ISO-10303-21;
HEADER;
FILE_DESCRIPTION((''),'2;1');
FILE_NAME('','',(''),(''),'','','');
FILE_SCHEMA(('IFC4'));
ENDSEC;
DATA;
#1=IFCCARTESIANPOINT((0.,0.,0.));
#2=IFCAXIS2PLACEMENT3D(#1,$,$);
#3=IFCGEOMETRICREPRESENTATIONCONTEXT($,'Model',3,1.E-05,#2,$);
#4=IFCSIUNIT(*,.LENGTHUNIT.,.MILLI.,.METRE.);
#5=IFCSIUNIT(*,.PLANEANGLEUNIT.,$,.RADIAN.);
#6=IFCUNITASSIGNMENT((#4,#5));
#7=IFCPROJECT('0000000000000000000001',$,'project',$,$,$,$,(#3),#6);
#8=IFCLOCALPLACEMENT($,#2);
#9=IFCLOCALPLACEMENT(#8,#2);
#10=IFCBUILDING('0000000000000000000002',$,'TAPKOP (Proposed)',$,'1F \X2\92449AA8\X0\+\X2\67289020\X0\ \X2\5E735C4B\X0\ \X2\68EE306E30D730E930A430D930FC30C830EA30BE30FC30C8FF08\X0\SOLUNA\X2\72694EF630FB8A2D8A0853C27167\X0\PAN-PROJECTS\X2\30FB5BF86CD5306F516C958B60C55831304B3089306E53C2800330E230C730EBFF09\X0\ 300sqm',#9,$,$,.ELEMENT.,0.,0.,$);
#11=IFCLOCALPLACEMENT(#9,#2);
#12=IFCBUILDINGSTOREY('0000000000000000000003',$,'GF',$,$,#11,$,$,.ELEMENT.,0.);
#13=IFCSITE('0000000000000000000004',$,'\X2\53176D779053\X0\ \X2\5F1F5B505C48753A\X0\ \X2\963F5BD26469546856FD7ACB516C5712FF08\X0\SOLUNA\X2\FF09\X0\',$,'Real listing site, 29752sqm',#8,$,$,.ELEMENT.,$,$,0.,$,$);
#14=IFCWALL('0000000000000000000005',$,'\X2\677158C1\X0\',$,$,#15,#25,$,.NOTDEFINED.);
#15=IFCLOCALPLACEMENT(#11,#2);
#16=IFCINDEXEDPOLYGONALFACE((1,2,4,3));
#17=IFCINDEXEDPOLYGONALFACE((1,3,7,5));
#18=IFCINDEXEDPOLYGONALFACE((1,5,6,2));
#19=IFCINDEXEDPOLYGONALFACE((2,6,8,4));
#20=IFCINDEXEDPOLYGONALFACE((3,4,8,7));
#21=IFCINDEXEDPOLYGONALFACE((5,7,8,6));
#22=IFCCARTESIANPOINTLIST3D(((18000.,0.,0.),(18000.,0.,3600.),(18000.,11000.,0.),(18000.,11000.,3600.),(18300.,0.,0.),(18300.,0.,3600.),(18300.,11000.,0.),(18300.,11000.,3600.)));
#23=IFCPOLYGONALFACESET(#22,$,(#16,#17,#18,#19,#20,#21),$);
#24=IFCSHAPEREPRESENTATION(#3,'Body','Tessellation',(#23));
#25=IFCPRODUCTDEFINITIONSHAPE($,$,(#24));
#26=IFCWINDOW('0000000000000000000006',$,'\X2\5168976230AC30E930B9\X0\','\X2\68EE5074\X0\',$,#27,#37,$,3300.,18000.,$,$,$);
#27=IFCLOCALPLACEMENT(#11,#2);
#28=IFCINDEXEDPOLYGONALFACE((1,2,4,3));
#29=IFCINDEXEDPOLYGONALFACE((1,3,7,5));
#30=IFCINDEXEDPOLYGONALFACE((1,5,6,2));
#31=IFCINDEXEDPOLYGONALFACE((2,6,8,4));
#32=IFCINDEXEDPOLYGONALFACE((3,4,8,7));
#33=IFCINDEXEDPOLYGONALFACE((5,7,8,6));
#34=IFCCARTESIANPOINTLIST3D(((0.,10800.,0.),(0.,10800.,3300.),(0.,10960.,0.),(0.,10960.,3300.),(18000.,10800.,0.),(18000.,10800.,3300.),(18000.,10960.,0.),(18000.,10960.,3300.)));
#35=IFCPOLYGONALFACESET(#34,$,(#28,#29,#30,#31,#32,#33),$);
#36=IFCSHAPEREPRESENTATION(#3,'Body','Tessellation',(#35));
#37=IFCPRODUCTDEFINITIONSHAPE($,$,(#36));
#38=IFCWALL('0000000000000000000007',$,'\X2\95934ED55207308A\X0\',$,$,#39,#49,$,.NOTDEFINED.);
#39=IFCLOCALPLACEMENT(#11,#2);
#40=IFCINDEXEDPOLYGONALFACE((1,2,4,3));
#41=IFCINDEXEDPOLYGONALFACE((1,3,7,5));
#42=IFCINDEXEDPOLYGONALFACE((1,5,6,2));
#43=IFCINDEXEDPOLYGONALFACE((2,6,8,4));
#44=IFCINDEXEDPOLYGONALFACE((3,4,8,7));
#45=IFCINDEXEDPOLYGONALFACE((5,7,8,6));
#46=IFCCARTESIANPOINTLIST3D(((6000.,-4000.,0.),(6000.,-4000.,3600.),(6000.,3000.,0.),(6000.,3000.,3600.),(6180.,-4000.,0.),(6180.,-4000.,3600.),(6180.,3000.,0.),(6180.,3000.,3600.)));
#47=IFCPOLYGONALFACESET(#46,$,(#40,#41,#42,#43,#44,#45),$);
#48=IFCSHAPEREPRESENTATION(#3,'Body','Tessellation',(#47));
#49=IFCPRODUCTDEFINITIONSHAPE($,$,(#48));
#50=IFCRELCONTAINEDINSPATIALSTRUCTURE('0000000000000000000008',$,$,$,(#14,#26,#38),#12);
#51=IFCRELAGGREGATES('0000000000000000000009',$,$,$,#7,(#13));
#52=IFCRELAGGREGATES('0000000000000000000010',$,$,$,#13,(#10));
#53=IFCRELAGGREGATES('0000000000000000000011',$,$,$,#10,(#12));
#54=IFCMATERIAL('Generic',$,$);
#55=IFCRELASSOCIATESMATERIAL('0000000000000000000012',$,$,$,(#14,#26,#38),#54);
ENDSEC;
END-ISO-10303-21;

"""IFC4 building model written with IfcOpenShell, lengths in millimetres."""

from ifc_helpers import new_model, si_unit, frame, frame_2d, origin, place, context, project, spatial, rectangle, extrude, material, element, fill, save


model = new_model("IFC4")

# Units and contexts
model_context = context("Model", 3, precision=1e-05, world=origin())
ifc_project = project(units=[si_unit("LENGTHUNIT", "METRE", prefix="MILLI"), si_unit("PLANEANGLEUNIT", "RADIAN")], contexts=[model_context])

# Site, building, storey
site_placement = place(None, origin())
site = spatial("IfcSite", under=ifc_project, at=site_placement, Name="北海道 弟子屈町 阿寒摩周国立公園（SOLUNA）", ObjectType="Real listing site, 29752sqm", CompositionType="ELEMENT", RefElevation=0.0)
building_placement = place(site_placement, origin())
building = spatial("IfcBuilding", under=site, at=building_placement, Name="TAPKOP (Proposed)", ObjectType="1F 鉄骨+木造 平屋 森のプライベートリゾート（SOLUNA物件・設計参照PAN-PROJECTS・寸法は公開情報からの参考モデル） 300sqm", CompositionType="ELEMENT", ElevationOfRefHeight=0.0, ElevationOfTerrain=0.0)
storey_placement = place(building_placement, origin())
storey = spatial("IfcBuildingStorey", under=building, at=storey_placement, Name="GF", CompositionType="ELEMENT", Elevation=0.0)

# Shared definitions
ifc_material_1 = material(Name="Generic")

# Wall, opening, window
wall_1_placement = place(storey_placement, frame((9000.0, 0.0, 0.0)))
wall_1 = element("IfcWall", 1, at=wall_1_placement, inside=storey, material=ifc_material_1, Name="東壁", PredefinedType="NOTDEFINED", context=model_context, shape_type="SweptSolid", body=[
    extrude(rectangle(XDim=300.0, YDim=11000.0, at=frame_2d((150.0, 5500.0))), frame((9000.0, 0.0, 0.0)), (0.0, 0.0, 1.0), 3600.0),
])
opening_placement = place(storey_placement, frame((0.0, 5400.0, 0.0)))
opening = element("IfcOpeningElement", 2, at=opening_placement, cuts=wall_1, PredefinedType="NOTDEFINED", context=model_context, shape_type="SweptSolid", body=[
    extrude(rectangle(XDim=18000.0, YDim=160.0, at=frame_2d((9000.0, 80.0))), frame((0.0, 5400.0, 0.0)), (0.0, 0.0, 1.0), 3300.0),
])
window_placement = place(storey_placement, frame((0.0, 5400.0, 0.0)))
window = element("IfcWindow", 3, at=window_placement, inside=storey, material=ifc_material_1, Name="全面ガラス", Description="森側", OverallHeight=3300.0, OverallWidth=18000.0, context=model_context, shape_type="SweptSolid", body=[
    extrude(rectangle(XDim=18000.0, YDim=160.0, at=frame_2d((9000.0, 80.0))), frame((0.0, 5400.0, 0.0)), (0.0, 0.0, 1.0), 3300.0),
])
fill(opening, window)

# Wall
wall_2_placement = place(storey_placement, frame((3000.0, -2000.0, 0.0)))
element("IfcWall", 4, at=wall_2_placement, inside=storey, material=ifc_material_1, Name="間仕切り", PredefinedType="NOTDEFINED", context=model_context, shape_type="SweptSolid", body=[
    extrude(rectangle(XDim=180.0, YDim=7000.0, at=frame_2d((90.0, 3500.0))), frame((3000.0, -2000.0, 0.0)), (0.0, 0.0, 1.0), 3600.0),
])

save(model, "model.ifc")
